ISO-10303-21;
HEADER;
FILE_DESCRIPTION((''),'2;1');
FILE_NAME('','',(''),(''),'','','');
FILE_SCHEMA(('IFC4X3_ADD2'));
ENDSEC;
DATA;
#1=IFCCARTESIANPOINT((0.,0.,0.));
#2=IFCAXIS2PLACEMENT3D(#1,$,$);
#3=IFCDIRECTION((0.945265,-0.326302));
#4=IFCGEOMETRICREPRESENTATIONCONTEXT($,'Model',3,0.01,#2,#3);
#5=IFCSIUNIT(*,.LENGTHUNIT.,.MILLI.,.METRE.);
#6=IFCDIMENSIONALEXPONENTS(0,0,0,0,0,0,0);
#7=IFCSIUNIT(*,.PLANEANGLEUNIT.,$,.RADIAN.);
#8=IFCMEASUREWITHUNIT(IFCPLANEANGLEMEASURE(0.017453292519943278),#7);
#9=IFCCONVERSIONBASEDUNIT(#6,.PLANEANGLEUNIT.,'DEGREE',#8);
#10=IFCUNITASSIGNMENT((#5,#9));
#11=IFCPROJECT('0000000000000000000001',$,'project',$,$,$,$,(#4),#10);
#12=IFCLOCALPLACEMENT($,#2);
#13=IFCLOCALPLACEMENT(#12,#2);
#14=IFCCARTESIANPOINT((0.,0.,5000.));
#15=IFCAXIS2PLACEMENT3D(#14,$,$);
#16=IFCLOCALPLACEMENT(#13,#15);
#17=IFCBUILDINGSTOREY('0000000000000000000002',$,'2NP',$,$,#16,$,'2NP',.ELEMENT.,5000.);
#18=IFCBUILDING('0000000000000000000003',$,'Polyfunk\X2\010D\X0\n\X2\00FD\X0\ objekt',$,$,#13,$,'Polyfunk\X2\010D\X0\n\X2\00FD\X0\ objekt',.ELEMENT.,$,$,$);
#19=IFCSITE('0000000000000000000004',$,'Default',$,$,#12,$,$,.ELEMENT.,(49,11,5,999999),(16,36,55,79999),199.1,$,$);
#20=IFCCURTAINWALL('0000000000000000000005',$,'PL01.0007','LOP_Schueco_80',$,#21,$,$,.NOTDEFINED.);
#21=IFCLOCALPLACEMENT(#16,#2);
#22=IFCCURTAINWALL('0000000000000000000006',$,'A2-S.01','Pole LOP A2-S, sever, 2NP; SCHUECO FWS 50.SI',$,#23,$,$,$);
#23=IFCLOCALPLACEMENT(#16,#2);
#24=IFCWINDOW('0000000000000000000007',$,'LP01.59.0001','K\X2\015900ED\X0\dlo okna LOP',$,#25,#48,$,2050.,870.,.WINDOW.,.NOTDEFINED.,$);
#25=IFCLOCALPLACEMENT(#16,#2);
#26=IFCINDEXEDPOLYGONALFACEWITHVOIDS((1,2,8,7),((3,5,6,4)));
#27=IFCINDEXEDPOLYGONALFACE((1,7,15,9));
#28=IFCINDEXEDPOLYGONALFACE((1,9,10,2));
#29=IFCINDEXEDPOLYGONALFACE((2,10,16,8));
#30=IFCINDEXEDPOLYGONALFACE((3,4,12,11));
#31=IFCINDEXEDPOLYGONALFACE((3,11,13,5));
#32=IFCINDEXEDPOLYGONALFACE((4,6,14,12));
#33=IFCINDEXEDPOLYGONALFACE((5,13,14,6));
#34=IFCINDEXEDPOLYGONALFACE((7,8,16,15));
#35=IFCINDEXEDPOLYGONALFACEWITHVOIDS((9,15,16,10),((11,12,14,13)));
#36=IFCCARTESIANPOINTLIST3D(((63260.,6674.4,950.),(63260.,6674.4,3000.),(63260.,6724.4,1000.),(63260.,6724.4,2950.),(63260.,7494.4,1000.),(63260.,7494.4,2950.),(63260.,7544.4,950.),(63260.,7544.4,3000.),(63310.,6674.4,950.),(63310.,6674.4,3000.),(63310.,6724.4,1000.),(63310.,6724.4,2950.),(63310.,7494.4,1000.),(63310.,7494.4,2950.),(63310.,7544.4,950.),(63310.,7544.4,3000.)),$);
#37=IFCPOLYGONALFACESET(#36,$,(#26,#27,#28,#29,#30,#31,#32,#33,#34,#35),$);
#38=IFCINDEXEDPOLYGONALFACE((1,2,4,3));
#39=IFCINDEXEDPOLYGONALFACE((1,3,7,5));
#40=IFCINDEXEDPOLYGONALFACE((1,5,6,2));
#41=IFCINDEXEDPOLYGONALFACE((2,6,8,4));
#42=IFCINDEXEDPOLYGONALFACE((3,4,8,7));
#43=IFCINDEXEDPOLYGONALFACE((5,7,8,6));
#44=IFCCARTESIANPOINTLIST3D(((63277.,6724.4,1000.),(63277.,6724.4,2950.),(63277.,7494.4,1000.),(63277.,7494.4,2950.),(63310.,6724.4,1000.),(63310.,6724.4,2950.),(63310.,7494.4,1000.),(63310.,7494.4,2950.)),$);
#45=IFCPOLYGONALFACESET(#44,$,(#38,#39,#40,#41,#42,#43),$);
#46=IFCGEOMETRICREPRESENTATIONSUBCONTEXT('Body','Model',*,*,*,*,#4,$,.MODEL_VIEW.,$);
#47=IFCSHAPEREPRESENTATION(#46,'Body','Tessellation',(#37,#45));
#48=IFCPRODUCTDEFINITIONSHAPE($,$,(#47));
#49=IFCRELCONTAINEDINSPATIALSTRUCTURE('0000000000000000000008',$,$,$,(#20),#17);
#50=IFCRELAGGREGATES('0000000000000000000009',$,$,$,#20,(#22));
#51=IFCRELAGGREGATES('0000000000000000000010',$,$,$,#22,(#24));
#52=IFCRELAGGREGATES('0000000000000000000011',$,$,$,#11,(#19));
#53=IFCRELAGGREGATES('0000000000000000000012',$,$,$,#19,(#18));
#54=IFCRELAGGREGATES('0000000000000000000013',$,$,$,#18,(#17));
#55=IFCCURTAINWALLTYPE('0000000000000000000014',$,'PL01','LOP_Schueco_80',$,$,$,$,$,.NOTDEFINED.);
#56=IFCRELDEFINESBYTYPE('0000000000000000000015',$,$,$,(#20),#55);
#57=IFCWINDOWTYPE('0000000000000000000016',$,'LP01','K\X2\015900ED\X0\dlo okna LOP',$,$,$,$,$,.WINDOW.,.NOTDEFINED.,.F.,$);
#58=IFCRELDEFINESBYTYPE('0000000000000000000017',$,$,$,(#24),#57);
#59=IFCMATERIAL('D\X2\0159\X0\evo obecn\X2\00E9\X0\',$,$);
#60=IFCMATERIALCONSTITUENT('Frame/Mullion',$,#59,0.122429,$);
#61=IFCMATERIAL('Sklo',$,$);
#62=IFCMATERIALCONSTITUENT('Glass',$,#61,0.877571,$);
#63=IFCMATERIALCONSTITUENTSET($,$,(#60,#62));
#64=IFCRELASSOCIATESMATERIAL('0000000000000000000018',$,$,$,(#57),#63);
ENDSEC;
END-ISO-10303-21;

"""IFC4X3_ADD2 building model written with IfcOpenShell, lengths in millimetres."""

from ifc_helpers import new_model, entity, si_unit, converted_unit, direction, frame, origin, origin_2d_with_axis, place, context, subcontext, project, spatial, polyline, rectangle, outline, extrude, source, transform, mapped, material, constituent, constituent_set, type_object, type_shapes, element, aggregate, save


model = new_model("IFC4X3_ADD2")

# Units and contexts
model_context = context("Model", 3, precision=0.01, world=origin(), true_north=direction((0.945265, -0.326302)))
body_context = subcontext(model_context, "Body", "Model", "MODEL_VIEW")
ifc_project = project(units=[si_unit("LENGTHUNIT", "METRE", prefix="MILLI"), converted_unit("PLANEANGLEUNIT", "DEGREE", entity("IfcPlaneAngleMeasure", 0.017453292519943278), si_unit("PLANEANGLEUNIT", "RADIAN"), dimensions=[0, 0, 0, 0, 0, 0, 0])], contexts=[model_context])

# Site, building, storey
site_placement = place(None, origin())
site = spatial("IfcSite", under=ifc_project, at=site_placement, Name="Default", CompositionType="ELEMENT", RefLatitude=(49, 11, 5, 999999), RefLongitude=(16, 36, 55, 79999), RefElevation=199.1)
building_placement = place(site_placement, origin())
building = spatial("IfcBuilding", under=site, at=building_placement, Name="Polyfunkčný objekt", LongName="Polyfunkčný objekt", CompositionType="ELEMENT")
storey_placement = place(building_placement, frame((0.0, 0.0, 5000.0)))
storey = spatial("IfcBuildingStorey", under=building, at=storey_placement, Name="2NP", LongName="2NP", CompositionType="ELEMENT", Elevation=5000.0)

# Curtain walls, window
curtain_wall_type = type_object("IfcCurtainWallType", Name="PL01", Description="LOP_Schueco_80", PredefinedType="NOTDEFINED")
curtain_wall_1_placement = place(storey_placement, frame((0.0, 0.0, -5000.0)))
curtain_wall_1 = element("IfcCurtainWall", 1, at=curtain_wall_1_placement, inside=storey, type_object=curtain_wall_type, Name="PL01.0007", Description="LOP_Schueco_80", PredefinedType="NOTDEFINED")
curtain_wall_2 = element("IfcCurtainWall", 2, Name="A2-S.01", Description="Pole LOP A2-S, sever, 2NP; SCHUECO FWS 50.SI")
aggregate(curtain_wall_1, [curtain_wall_2])
ifc_material_1 = material(Name="Sklo")
ifc_material_2 = material(Name="Dřevo obecné")
ifc_constituent_1 = constituent(ifc_material_2, Name="Frame/Mullion", fraction=0.122429)
ifc_constituent_2 = constituent(ifc_material_1, Name="Glass", fraction=0.877571)
ifc_constituent_set = constituent_set(constituents=[ifc_constituent_1, ifc_constituent_2])
window_type = type_object("IfcWindowType", Name="LP01", Description="Křídlo okna LOP", ParameterTakesPrecedence=False, PartitioningType="NOTDEFINED", PredefinedType="WINDOW", material=ifc_constituent_set)
shared_shape_1 = source(origin(), body_context, "Body", "SweptSolid", [
    extrude(outline(polyline([(-1025.0, -435.0), (1025.0, -435.0), (1025.0, 435.0), (-1025.0, 435.0), (-1025.0, -435.0)]), holes=[polyline([(-975.0, -385.0), (-975.0, 385.0), (975.0, 385.0), (975.0, -385.0), (-975.0, -385.0)])]), frame((0.0, 0.0, 1025.0), z_axis=(0.0, 1.0, 0.0), x_axis=(0.0, 0.0, -1.0)), (0.0, 0.0, 1.0), 50.0),
    extrude(rectangle(XDim=33.0, YDim=770.0, at=origin_2d_with_axis()), frame((0.0, 33.5, 50.0), z_axis=(0.0, 0.0, 1.0), x_axis=(0.0, -1.0, 0.0)), (0.0, 0.0, 1.0), 1950.0),
])
type_shapes(window_type, [shared_shape_1])
window_placement = place(curtain_wall_1_placement, frame((63260.0, 7109.4, 5950.0), z_axis=(0.0, 0.0, 1.0), x_axis=(0.0, -1.0, 0.0)))
window = element("IfcWindow", 3, at=window_placement, type_object=window_type, Name="LP01.59.0001", Description="Křídlo okna LOP", OverallHeight=2050.0, OverallWidth=870.0, PartitioningType="NOTDEFINED", PredefinedType="WINDOW", context=body_context, shape_type="MappedRepresentation", body=[
    mapped(shared_shape_1, transform((0.0, 0.0, 0.0), scale=1.0)),
])
aggregate(curtain_wall_2, [window])

save(model, "model.ifc")
